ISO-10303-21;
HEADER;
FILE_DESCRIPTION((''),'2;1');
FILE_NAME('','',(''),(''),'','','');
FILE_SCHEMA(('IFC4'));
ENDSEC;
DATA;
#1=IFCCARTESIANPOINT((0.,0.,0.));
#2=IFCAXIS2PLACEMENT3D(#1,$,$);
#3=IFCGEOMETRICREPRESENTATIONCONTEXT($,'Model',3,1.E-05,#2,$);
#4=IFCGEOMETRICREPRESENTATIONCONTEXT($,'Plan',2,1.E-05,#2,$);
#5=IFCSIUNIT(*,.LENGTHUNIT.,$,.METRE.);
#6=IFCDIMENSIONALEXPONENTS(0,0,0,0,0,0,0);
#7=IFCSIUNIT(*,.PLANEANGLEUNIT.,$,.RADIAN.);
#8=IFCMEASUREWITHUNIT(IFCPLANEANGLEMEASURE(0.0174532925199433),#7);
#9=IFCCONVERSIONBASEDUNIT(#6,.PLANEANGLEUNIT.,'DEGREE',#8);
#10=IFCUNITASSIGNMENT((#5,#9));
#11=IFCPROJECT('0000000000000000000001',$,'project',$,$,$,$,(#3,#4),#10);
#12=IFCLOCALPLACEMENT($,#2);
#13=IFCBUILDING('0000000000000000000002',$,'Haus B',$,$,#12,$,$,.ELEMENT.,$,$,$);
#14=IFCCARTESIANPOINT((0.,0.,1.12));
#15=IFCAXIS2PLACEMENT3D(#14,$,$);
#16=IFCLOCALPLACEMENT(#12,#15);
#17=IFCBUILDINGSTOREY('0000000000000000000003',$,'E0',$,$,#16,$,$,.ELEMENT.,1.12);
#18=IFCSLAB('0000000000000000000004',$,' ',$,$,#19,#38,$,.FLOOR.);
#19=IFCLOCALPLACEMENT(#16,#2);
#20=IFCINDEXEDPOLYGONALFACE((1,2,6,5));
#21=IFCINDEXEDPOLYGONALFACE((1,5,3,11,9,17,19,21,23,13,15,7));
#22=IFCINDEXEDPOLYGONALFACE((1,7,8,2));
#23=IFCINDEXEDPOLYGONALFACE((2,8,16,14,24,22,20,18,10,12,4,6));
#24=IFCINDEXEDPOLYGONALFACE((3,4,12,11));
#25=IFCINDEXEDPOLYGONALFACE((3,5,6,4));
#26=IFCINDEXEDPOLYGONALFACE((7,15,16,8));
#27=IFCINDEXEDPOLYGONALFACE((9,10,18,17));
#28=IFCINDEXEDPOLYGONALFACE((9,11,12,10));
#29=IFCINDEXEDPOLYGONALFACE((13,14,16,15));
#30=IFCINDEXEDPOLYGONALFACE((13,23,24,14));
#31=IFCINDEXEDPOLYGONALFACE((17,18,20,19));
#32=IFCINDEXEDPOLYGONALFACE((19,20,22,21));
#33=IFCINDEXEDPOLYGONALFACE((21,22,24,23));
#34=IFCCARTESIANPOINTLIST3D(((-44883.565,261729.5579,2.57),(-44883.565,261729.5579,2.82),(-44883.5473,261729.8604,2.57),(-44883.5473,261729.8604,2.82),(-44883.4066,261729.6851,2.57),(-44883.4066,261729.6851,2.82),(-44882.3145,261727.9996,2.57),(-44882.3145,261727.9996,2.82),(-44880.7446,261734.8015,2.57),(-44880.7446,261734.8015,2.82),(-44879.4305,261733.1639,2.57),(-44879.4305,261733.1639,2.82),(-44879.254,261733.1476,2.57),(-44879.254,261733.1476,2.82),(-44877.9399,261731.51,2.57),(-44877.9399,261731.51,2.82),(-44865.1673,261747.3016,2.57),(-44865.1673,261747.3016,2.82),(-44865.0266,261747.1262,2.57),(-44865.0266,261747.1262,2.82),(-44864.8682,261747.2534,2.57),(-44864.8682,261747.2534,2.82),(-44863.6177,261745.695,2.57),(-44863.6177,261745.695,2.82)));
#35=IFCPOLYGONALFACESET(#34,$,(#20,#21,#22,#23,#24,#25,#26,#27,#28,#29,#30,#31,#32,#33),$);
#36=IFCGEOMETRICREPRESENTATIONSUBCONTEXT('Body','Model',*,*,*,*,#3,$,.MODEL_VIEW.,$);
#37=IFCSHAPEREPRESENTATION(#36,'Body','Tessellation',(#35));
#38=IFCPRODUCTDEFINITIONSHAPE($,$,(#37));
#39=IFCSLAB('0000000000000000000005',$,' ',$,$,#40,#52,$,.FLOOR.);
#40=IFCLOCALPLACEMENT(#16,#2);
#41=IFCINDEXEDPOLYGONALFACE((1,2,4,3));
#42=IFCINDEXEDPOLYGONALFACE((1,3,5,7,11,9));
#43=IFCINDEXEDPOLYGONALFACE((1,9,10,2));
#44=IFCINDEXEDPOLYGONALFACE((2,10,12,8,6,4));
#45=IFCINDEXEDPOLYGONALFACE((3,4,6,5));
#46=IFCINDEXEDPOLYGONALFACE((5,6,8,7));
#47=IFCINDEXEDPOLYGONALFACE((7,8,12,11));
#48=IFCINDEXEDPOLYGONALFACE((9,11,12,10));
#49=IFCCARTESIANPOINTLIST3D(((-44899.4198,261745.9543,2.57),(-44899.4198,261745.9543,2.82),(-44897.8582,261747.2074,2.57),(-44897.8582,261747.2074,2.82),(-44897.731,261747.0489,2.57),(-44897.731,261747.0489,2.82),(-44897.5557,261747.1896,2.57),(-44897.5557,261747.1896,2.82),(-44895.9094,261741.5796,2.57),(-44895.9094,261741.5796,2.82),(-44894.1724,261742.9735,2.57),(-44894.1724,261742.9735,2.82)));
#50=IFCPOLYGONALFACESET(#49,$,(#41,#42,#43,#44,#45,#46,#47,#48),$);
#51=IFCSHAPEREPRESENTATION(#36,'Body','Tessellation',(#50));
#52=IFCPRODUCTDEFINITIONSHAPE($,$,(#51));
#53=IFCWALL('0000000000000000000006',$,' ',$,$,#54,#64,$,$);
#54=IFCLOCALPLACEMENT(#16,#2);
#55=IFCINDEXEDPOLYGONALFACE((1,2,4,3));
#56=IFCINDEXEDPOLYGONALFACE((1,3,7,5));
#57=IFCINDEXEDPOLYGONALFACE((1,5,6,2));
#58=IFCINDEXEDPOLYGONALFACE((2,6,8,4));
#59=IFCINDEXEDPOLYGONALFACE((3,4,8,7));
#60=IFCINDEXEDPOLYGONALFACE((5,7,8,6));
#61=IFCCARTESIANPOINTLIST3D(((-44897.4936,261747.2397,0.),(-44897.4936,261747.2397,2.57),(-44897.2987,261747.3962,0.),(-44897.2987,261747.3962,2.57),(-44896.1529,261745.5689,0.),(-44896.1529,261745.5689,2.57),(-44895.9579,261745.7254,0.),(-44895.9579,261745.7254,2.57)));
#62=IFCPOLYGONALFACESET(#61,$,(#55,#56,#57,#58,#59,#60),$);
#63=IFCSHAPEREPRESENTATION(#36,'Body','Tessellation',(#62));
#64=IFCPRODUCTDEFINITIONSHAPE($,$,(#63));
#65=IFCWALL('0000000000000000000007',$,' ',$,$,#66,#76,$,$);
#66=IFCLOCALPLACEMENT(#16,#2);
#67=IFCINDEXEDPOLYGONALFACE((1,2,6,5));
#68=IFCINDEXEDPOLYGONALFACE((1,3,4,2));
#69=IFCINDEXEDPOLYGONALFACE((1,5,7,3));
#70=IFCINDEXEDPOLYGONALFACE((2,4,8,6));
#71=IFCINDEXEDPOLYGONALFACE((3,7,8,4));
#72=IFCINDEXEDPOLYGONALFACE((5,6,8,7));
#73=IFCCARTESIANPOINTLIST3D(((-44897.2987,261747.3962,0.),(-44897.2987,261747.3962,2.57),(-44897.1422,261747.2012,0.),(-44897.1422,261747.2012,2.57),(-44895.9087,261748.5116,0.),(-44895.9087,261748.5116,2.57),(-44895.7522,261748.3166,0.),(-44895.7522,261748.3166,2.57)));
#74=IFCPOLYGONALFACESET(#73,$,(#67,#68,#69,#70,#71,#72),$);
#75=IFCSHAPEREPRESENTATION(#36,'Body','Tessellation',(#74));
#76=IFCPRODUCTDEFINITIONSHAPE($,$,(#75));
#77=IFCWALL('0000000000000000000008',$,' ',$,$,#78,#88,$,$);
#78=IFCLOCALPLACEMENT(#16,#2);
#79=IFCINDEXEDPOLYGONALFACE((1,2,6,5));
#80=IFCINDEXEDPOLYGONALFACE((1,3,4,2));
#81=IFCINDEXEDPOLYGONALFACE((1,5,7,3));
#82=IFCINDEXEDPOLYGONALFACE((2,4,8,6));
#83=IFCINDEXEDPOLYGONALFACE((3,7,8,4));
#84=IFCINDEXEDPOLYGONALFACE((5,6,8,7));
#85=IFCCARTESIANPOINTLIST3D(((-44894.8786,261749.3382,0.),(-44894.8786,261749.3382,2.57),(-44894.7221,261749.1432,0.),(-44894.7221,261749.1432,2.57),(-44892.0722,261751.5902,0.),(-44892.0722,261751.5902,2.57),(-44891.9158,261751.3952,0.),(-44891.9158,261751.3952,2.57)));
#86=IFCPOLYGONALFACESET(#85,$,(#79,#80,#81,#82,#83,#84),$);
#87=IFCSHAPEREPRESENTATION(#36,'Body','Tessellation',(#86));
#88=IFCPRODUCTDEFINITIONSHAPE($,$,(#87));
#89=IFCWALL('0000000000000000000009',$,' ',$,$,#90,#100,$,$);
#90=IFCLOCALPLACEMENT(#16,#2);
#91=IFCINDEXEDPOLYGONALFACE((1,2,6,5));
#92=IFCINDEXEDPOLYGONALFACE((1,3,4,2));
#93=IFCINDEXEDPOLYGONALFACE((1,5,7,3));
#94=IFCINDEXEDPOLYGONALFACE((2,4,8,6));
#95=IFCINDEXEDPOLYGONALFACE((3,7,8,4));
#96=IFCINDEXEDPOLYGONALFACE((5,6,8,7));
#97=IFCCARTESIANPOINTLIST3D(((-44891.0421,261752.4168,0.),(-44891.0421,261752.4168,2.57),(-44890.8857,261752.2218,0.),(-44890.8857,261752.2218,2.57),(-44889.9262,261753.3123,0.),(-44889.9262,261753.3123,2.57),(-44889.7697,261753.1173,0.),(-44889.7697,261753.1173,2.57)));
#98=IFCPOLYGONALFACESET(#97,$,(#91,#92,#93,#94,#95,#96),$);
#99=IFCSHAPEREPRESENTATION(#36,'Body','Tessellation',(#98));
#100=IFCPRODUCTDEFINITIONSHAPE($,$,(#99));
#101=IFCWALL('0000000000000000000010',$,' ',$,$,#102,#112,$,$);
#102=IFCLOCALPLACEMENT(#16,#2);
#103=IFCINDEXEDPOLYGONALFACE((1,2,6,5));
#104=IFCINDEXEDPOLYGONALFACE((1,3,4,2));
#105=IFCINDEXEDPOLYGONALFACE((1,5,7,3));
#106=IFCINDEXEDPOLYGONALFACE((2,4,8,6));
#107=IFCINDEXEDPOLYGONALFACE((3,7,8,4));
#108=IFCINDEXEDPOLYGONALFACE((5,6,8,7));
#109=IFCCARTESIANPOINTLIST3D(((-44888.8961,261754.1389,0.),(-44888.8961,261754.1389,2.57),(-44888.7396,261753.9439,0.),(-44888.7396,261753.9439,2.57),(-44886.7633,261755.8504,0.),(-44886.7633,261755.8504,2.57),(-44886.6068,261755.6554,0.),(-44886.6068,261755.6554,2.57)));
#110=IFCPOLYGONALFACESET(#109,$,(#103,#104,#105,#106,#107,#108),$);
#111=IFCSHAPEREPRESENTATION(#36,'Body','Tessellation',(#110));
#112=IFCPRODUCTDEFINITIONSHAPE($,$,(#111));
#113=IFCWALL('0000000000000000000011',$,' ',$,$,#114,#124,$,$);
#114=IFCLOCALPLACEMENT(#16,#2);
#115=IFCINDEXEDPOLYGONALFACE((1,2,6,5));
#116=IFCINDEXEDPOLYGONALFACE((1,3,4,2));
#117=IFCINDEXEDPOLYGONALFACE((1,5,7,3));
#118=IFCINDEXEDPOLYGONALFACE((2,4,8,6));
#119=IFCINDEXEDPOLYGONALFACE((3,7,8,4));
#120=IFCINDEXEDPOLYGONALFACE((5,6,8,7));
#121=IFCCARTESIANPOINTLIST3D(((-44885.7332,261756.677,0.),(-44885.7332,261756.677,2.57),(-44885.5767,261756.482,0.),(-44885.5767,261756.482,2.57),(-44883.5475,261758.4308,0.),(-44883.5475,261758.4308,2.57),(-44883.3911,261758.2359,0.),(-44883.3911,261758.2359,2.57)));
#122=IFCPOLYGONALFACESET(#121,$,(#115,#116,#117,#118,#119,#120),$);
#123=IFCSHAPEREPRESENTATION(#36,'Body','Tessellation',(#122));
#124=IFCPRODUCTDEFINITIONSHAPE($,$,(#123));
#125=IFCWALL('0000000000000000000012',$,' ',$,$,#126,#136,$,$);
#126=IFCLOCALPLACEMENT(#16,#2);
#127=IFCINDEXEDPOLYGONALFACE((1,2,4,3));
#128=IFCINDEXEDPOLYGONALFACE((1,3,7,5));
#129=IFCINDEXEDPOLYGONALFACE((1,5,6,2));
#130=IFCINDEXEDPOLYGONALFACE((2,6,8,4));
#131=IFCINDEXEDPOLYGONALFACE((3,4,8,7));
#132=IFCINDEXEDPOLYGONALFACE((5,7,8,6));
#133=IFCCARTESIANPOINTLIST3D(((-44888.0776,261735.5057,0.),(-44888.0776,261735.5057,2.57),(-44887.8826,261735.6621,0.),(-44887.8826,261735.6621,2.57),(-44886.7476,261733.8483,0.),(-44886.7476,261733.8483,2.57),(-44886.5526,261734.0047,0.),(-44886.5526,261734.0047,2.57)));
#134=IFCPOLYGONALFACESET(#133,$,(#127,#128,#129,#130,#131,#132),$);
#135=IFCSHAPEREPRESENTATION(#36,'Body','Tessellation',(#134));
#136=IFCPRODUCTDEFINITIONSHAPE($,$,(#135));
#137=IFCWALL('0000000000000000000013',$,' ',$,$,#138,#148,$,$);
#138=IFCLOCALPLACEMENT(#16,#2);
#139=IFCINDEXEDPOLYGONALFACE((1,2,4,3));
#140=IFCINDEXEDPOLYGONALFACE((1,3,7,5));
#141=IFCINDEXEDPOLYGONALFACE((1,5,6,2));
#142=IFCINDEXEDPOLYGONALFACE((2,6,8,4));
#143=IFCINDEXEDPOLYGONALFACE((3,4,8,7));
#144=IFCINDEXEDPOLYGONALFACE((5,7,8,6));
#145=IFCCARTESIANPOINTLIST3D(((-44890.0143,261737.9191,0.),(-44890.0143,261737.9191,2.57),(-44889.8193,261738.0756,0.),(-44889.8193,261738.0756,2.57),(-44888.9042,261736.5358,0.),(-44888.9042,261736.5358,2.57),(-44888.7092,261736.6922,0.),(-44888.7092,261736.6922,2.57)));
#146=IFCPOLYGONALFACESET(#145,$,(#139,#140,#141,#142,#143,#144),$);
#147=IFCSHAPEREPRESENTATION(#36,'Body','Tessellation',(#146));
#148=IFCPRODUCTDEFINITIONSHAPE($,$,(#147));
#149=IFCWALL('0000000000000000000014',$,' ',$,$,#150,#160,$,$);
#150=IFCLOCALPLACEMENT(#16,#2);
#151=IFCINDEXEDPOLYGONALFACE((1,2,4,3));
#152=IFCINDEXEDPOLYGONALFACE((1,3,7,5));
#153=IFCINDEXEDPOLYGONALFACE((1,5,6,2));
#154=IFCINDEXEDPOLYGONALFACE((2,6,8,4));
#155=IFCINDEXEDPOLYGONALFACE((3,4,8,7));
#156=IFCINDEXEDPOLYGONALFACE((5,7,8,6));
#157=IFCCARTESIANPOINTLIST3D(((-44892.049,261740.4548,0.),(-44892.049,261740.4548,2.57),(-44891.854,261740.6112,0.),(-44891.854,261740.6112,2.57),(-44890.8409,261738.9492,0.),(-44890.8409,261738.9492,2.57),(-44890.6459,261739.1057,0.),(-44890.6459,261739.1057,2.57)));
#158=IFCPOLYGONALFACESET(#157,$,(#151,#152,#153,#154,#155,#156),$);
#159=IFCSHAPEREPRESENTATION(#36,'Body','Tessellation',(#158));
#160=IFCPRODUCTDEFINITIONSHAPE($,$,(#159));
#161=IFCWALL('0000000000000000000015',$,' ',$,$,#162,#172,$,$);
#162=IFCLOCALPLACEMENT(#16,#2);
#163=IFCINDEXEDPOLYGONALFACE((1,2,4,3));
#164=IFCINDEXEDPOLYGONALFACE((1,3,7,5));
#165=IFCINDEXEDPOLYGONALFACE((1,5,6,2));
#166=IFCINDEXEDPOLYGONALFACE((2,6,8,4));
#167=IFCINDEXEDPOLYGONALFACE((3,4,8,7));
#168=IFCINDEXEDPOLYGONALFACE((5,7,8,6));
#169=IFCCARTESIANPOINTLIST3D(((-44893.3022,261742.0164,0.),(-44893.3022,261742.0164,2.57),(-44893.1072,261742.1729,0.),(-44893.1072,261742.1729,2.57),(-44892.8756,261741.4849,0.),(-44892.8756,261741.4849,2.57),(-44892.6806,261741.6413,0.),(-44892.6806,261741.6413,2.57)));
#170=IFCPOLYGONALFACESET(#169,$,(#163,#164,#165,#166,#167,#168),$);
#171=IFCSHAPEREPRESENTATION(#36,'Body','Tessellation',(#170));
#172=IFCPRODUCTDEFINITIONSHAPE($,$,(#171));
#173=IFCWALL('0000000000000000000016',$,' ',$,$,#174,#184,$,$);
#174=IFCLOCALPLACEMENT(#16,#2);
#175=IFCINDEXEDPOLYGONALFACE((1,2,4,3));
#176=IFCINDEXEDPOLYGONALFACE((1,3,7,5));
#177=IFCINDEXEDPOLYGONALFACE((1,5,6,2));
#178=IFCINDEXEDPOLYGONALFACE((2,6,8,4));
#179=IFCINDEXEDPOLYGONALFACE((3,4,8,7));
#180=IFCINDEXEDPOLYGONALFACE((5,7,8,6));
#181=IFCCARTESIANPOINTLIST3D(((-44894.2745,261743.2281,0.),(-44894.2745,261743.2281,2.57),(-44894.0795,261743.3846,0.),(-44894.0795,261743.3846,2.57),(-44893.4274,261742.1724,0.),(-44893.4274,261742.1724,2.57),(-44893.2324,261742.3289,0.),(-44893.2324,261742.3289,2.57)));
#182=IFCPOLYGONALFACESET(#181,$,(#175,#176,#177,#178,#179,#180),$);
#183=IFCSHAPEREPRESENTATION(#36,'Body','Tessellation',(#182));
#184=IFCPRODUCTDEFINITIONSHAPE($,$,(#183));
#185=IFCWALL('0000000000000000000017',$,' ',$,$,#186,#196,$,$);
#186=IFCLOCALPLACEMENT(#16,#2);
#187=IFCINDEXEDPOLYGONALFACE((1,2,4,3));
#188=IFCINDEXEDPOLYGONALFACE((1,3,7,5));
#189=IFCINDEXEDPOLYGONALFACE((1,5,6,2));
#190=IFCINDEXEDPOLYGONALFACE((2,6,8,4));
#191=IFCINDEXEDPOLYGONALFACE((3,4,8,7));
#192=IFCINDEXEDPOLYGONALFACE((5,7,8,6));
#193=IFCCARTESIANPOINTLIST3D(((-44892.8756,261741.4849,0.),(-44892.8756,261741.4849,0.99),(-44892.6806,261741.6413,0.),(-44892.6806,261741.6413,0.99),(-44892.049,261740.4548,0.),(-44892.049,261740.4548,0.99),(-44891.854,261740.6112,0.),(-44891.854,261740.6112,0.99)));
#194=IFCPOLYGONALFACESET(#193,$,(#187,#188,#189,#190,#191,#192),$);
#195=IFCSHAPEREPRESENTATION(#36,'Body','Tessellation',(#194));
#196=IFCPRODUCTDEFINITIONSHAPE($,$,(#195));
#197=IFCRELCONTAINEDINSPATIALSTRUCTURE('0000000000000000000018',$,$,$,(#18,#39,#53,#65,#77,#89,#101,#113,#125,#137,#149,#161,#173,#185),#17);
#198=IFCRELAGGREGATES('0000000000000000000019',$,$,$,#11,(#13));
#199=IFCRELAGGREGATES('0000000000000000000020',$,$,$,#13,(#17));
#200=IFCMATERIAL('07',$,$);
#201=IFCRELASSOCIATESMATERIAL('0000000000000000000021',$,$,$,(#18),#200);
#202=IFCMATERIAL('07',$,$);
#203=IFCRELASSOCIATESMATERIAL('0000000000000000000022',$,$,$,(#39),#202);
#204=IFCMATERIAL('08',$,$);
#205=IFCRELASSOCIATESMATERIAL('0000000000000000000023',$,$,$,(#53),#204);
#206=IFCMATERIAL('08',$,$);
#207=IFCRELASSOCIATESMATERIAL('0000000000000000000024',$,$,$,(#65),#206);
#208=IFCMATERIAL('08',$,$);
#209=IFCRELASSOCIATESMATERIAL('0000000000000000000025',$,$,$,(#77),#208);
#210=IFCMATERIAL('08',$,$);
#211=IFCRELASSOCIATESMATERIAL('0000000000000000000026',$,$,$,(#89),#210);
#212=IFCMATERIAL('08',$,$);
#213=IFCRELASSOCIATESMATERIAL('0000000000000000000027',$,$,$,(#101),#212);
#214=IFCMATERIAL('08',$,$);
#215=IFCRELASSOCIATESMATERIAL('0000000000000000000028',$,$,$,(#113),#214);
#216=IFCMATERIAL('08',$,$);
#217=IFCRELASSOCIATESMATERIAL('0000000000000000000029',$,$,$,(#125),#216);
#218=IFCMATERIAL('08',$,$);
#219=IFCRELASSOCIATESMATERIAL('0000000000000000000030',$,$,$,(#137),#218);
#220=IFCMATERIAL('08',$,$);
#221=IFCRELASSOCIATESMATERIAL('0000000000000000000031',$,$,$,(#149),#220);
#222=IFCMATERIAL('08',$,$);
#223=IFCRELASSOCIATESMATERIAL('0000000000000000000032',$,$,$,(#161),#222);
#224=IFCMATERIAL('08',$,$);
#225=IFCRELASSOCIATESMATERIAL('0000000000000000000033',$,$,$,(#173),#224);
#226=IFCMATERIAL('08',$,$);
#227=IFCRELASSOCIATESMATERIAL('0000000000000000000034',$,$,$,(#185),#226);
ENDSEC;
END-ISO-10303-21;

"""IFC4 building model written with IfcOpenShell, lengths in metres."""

from ifc_helpers import new_model, entity, si_unit, converted_unit, frame, frame_2d, origin, origin_with_axes, place, context, subcontext, project, spatial, polyline, rectangle, outline, extrude, material, element, save


model = new_model("IFC4")

# Units and contexts
model_context = context("Model", 3, precision=1e-05, world=origin())
plan_context = context("Plan", 2, precision=1e-05, world=origin())
body_context = subcontext(model_context, "Body", "Model", "MODEL_VIEW")
ifc_project = project(units=[si_unit("LENGTHUNIT", "METRE"), converted_unit("PLANEANGLEUNIT", "DEGREE", entity("IfcPlaneAngleMeasure", 0.0174532925199433), si_unit("PLANEANGLEUNIT", "RADIAN"), dimensions=[0, 0, 0, 0, 0, 0, 0])], contexts=[model_context, plan_context])

# Building, storey
building_placement = place(None, origin())
building = spatial("IfcBuilding", under=ifc_project, at=building_placement, Name="Haus B", CompositionType="ELEMENT")
storey_placement = place(building_placement, frame((0.0, 0.0, 1.12)))
storey = spatial("IfcBuildingStorey", under=building, at=storey_placement, Name="E0", CompositionType="ELEMENT", Elevation=1.12)

# Slabs
ifc_material_1 = material(Name="07")
slab_1_placement = place(storey_placement, frame((-44883.565, 261727.9996, 2.57)))
element("IfcSlab", 1, at=slab_1_placement, inside=storey, material=ifc_material_1, Name=" ", PredefinedType="FLOOR", context=body_context, shape_type="SweptSolid", body=[
    extrude(outline(polyline([(18.3977, 19.302), (2.8205, 6.8019), (4.1345, 5.1643), (0.0178, 1.8608), (0.1585, 1.6855), (0.0, 1.5584), (1.2505, 0.0), (5.6251, 3.5104), (4.311, 5.148), (19.9474, 17.6955), (18.6969, 19.2538), (18.5384, 19.1266), (18.3977, 19.302)])), origin_with_axes(), (0.0, 0.0, 1.0), 0.25),
])
ifc_material_2 = material(Name="07")
slab_2_placement = place(storey_placement, frame((-44899.4198, 261741.5796, 2.57)))
element("IfcSlab", 2, at=slab_2_placement, inside=storey, material=ifc_material_2, Name=" ", PredefinedType="FLOOR", context=body_context, shape_type="SweptSolid", body=[
    extrude(outline(polyline([(1.8641, 5.61), (1.6888, 5.4693), (1.5617, 5.6278), (0.0, 4.3746), (3.5104, 0.0), (5.2474, 1.3938), (1.8641, 5.61)])), origin_with_axes(), (0.0, 0.0, 1.0), 0.25),
])

# Walls
ifc_material_3 = material(Name="08")
wall_1_placement = place(storey_placement, frame((-44895.9579, 261745.7254, 0.0), z_axis=(0.0, 0.0, 1.0), x_axis=(-0.625861, 0.779935, 0.0)))
element("IfcWall", 3, at=wall_1_placement, inside=storey, material=ifc_material_3, Name=" ", context=body_context, shape_type="SweptSolid", body=[
    extrude(rectangle(XDim=2.1422, YDim=0.25, at=frame_2d((1.0711, 0.125), x_axis=(1.0, 0.0))), origin_with_axes(), (0.0, 0.0, 1.0), 2.57),
])
ifc_material_4 = material(Name="08")
wall_2_placement = place(storey_placement, frame((-44897.1422, 261747.2012, 0.0), z_axis=(0.0, 0.0, 1.0), x_axis=(0.779935, 0.625861, 0.0)))
element("IfcWall", 4, at=wall_2_placement, inside=storey, material=ifc_material_4, Name=" ", context=body_context, shape_type="SweptSolid", body=[
    extrude(rectangle(XDim=1.7822, YDim=0.25, at=frame_2d((0.8911, 0.125), x_axis=(1.0, 0.0))), origin_with_axes(), (0.0, 0.0, 1.0), 2.57),
])
ifc_material_5 = material(Name="08")
wall_3_placement = place(storey_placement, frame((-44894.7221, 261749.1432, 0.0), z_axis=(0.0, 0.0, 1.0), x_axis=(0.779935, 0.625861, 0.0)))
element("IfcWall", 5, at=wall_3_placement, inside=storey, material=ifc_material_5, Name=" ", context=body_context, shape_type="SweptSolid", body=[
    extrude(rectangle(XDim=3.5982, YDim=0.25, at=frame_2d((1.7991, 0.125), x_axis=(1.0, 0.0))), origin_with_axes(), (0.0, 0.0, 1.0), 2.57),
])
ifc_material_6 = material(Name="08")
wall_4_placement = place(storey_placement, frame((-44890.8857, 261752.2218, 0.0), z_axis=(0.0, 0.0, 1.0), x_axis=(0.779935, 0.625861, 0.0)))
element("IfcWall", 6, at=wall_4_placement, inside=storey, material=ifc_material_6, Name=" ", context=body_context, shape_type="SweptSolid", body=[
    extrude(rectangle(XDim=1.4308, YDim=0.25, at=frame_2d((0.7154, 0.125), x_axis=(1.0, 0.0))), origin_with_axes(), (0.0, 0.0, 1.0), 2.57),
])
ifc_material_7 = material(Name="08")
wall_5_placement = place(storey_placement, frame((-44888.7396, 261753.9439, 0.0), z_axis=(0.0, 0.0, 1.0), x_axis=(0.779935, 0.625861, 0.0)))
element("IfcWall", 7, at=wall_5_placement, inside=storey, material=ifc_material_7, Name=" ", context=body_context, shape_type="SweptSolid", body=[
    extrude(rectangle(XDim=2.7346, YDim=0.25, at=frame_2d((1.3673, 0.125), x_axis=(1.0, 0.0))), origin_with_axes(), (0.0, 0.0, 1.0), 2.57),
])
ifc_material_8 = material(Name="08")
wall_6_placement = place(storey_placement, frame((-44885.5767, 261756.482, 0.0), z_axis=(0.0, 0.0, 1.0), x_axis=(0.779935, 0.625861, 0.0)))
element("IfcWall", 8, at=wall_6_placement, inside=storey, material=ifc_material_8, Name=" ", context=body_context, shape_type="SweptSolid", body=[
    extrude(rectangle(XDim=2.8024, YDim=0.25, at=frame_2d((1.4012, 0.125), x_axis=(1.0, 0.0))), origin_with_axes(), (0.0, 0.0, 1.0), 2.57),
])
ifc_material_9 = material(Name="08")
wall_7_placement = place(storey_placement, frame((-44886.5526, 261734.0047, 0.0), z_axis=(0.0, 0.0, 1.0), x_axis=(-0.625861, 0.779935, 0.0)))
element("IfcWall", 9, at=wall_7_placement, inside=storey, material=ifc_material_9, Name=" ", context=body_context, shape_type="SweptSolid", body=[
    extrude(rectangle(XDim=2.1251, YDim=0.25, at=frame_2d((1.0625, 0.125), x_axis=(1.0, 0.0))), origin_with_axes(), (0.0, 0.0, 1.0), 2.57),
])
ifc_material_10 = material(Name="08")
wall_8_placement = place(storey_placement, frame((-44888.7092, 261736.6922, 0.0), z_axis=(0.0, 0.0, 1.0), x_axis=(-0.625861, 0.779935, 0.0)))
element("IfcWall", 10, at=wall_8_placement, inside=storey, material=ifc_material_10, Name=" ", context=body_context, shape_type="SweptSolid", body=[
    extrude(rectangle(XDim=1.7737, YDim=0.25, at=frame_2d((0.8868, 0.125), x_axis=(1.0, 0.0))), origin_with_axes(), (0.0, 0.0, 1.0), 2.57),
])
ifc_material_11 = material(Name="08")
wall_9_placement = place(storey_placement, frame((-44890.6459, 261739.1057, 0.0), z_axis=(0.0, 0.0, 1.0), x_axis=(-0.625861, 0.779935, 0.0)))
element("IfcWall", 11, at=wall_9_placement, inside=storey, material=ifc_material_11, Name=" ", context=body_context, shape_type="SweptSolid", body=[
    extrude(rectangle(XDim=1.9303, YDim=0.25, at=frame_2d((0.9652, 0.125), x_axis=(1.0, 0.0))), origin_with_axes(), (0.0, 0.0, 1.0), 2.57),
])
ifc_material_12 = material(Name="08")
wall_10_placement = place(storey_placement, frame((-44892.6806, 261741.6413, 0.0), z_axis=(0.0, 0.0, 1.0), x_axis=(-0.625861, 0.779935, 0.0)))
element("IfcWall", 12, at=wall_10_placement, inside=storey, material=ifc_material_12, Name=" ", context=body_context, shape_type="SweptSolid", body=[
    extrude(rectangle(XDim=0.6815, YDim=0.25, at=frame_2d((0.3408, 0.125), x_axis=(1.0, 0.0))), origin_with_axes(), (0.0, 0.0, 1.0), 2.57),
])
ifc_material_13 = material(Name="08")
wall_11_placement = place(storey_placement, frame((-44893.2324, 261742.3289, 0.0), z_axis=(0.0, 0.0, 1.0), x_axis=(-0.625861, 0.779935, 0.0)))
element("IfcWall", 13, at=wall_11_placement, inside=storey, material=ifc_material_13, Name=" ", context=body_context, shape_type="SweptSolid", body=[
    extrude(rectangle(XDim=1.3536, YDim=0.25, at=frame_2d((0.6768, 0.125), x_axis=(1.0, 0.0))), origin_with_axes(), (0.0, 0.0, 1.0), 2.57),
])
ifc_material_14 = material(Name="08")
wall_12_placement = place(storey_placement, frame((-44891.854, 261740.6112, 0.0), z_axis=(0.0, 0.0, 1.0), x_axis=(-0.625861, 0.779935, 0.0)))
element("IfcWall", 14, at=wall_12_placement, inside=storey, material=ifc_material_14, Name=" ", context=body_context, shape_type="SweptSolid", body=[
    extrude(rectangle(XDim=1.3207, YDim=0.25, at=frame_2d((0.6604, 0.125), x_axis=(1.0, 0.0))), origin_with_axes(), (0.0, 0.0, 1.0), 0.99),
])

save(model, "model.ifc")
